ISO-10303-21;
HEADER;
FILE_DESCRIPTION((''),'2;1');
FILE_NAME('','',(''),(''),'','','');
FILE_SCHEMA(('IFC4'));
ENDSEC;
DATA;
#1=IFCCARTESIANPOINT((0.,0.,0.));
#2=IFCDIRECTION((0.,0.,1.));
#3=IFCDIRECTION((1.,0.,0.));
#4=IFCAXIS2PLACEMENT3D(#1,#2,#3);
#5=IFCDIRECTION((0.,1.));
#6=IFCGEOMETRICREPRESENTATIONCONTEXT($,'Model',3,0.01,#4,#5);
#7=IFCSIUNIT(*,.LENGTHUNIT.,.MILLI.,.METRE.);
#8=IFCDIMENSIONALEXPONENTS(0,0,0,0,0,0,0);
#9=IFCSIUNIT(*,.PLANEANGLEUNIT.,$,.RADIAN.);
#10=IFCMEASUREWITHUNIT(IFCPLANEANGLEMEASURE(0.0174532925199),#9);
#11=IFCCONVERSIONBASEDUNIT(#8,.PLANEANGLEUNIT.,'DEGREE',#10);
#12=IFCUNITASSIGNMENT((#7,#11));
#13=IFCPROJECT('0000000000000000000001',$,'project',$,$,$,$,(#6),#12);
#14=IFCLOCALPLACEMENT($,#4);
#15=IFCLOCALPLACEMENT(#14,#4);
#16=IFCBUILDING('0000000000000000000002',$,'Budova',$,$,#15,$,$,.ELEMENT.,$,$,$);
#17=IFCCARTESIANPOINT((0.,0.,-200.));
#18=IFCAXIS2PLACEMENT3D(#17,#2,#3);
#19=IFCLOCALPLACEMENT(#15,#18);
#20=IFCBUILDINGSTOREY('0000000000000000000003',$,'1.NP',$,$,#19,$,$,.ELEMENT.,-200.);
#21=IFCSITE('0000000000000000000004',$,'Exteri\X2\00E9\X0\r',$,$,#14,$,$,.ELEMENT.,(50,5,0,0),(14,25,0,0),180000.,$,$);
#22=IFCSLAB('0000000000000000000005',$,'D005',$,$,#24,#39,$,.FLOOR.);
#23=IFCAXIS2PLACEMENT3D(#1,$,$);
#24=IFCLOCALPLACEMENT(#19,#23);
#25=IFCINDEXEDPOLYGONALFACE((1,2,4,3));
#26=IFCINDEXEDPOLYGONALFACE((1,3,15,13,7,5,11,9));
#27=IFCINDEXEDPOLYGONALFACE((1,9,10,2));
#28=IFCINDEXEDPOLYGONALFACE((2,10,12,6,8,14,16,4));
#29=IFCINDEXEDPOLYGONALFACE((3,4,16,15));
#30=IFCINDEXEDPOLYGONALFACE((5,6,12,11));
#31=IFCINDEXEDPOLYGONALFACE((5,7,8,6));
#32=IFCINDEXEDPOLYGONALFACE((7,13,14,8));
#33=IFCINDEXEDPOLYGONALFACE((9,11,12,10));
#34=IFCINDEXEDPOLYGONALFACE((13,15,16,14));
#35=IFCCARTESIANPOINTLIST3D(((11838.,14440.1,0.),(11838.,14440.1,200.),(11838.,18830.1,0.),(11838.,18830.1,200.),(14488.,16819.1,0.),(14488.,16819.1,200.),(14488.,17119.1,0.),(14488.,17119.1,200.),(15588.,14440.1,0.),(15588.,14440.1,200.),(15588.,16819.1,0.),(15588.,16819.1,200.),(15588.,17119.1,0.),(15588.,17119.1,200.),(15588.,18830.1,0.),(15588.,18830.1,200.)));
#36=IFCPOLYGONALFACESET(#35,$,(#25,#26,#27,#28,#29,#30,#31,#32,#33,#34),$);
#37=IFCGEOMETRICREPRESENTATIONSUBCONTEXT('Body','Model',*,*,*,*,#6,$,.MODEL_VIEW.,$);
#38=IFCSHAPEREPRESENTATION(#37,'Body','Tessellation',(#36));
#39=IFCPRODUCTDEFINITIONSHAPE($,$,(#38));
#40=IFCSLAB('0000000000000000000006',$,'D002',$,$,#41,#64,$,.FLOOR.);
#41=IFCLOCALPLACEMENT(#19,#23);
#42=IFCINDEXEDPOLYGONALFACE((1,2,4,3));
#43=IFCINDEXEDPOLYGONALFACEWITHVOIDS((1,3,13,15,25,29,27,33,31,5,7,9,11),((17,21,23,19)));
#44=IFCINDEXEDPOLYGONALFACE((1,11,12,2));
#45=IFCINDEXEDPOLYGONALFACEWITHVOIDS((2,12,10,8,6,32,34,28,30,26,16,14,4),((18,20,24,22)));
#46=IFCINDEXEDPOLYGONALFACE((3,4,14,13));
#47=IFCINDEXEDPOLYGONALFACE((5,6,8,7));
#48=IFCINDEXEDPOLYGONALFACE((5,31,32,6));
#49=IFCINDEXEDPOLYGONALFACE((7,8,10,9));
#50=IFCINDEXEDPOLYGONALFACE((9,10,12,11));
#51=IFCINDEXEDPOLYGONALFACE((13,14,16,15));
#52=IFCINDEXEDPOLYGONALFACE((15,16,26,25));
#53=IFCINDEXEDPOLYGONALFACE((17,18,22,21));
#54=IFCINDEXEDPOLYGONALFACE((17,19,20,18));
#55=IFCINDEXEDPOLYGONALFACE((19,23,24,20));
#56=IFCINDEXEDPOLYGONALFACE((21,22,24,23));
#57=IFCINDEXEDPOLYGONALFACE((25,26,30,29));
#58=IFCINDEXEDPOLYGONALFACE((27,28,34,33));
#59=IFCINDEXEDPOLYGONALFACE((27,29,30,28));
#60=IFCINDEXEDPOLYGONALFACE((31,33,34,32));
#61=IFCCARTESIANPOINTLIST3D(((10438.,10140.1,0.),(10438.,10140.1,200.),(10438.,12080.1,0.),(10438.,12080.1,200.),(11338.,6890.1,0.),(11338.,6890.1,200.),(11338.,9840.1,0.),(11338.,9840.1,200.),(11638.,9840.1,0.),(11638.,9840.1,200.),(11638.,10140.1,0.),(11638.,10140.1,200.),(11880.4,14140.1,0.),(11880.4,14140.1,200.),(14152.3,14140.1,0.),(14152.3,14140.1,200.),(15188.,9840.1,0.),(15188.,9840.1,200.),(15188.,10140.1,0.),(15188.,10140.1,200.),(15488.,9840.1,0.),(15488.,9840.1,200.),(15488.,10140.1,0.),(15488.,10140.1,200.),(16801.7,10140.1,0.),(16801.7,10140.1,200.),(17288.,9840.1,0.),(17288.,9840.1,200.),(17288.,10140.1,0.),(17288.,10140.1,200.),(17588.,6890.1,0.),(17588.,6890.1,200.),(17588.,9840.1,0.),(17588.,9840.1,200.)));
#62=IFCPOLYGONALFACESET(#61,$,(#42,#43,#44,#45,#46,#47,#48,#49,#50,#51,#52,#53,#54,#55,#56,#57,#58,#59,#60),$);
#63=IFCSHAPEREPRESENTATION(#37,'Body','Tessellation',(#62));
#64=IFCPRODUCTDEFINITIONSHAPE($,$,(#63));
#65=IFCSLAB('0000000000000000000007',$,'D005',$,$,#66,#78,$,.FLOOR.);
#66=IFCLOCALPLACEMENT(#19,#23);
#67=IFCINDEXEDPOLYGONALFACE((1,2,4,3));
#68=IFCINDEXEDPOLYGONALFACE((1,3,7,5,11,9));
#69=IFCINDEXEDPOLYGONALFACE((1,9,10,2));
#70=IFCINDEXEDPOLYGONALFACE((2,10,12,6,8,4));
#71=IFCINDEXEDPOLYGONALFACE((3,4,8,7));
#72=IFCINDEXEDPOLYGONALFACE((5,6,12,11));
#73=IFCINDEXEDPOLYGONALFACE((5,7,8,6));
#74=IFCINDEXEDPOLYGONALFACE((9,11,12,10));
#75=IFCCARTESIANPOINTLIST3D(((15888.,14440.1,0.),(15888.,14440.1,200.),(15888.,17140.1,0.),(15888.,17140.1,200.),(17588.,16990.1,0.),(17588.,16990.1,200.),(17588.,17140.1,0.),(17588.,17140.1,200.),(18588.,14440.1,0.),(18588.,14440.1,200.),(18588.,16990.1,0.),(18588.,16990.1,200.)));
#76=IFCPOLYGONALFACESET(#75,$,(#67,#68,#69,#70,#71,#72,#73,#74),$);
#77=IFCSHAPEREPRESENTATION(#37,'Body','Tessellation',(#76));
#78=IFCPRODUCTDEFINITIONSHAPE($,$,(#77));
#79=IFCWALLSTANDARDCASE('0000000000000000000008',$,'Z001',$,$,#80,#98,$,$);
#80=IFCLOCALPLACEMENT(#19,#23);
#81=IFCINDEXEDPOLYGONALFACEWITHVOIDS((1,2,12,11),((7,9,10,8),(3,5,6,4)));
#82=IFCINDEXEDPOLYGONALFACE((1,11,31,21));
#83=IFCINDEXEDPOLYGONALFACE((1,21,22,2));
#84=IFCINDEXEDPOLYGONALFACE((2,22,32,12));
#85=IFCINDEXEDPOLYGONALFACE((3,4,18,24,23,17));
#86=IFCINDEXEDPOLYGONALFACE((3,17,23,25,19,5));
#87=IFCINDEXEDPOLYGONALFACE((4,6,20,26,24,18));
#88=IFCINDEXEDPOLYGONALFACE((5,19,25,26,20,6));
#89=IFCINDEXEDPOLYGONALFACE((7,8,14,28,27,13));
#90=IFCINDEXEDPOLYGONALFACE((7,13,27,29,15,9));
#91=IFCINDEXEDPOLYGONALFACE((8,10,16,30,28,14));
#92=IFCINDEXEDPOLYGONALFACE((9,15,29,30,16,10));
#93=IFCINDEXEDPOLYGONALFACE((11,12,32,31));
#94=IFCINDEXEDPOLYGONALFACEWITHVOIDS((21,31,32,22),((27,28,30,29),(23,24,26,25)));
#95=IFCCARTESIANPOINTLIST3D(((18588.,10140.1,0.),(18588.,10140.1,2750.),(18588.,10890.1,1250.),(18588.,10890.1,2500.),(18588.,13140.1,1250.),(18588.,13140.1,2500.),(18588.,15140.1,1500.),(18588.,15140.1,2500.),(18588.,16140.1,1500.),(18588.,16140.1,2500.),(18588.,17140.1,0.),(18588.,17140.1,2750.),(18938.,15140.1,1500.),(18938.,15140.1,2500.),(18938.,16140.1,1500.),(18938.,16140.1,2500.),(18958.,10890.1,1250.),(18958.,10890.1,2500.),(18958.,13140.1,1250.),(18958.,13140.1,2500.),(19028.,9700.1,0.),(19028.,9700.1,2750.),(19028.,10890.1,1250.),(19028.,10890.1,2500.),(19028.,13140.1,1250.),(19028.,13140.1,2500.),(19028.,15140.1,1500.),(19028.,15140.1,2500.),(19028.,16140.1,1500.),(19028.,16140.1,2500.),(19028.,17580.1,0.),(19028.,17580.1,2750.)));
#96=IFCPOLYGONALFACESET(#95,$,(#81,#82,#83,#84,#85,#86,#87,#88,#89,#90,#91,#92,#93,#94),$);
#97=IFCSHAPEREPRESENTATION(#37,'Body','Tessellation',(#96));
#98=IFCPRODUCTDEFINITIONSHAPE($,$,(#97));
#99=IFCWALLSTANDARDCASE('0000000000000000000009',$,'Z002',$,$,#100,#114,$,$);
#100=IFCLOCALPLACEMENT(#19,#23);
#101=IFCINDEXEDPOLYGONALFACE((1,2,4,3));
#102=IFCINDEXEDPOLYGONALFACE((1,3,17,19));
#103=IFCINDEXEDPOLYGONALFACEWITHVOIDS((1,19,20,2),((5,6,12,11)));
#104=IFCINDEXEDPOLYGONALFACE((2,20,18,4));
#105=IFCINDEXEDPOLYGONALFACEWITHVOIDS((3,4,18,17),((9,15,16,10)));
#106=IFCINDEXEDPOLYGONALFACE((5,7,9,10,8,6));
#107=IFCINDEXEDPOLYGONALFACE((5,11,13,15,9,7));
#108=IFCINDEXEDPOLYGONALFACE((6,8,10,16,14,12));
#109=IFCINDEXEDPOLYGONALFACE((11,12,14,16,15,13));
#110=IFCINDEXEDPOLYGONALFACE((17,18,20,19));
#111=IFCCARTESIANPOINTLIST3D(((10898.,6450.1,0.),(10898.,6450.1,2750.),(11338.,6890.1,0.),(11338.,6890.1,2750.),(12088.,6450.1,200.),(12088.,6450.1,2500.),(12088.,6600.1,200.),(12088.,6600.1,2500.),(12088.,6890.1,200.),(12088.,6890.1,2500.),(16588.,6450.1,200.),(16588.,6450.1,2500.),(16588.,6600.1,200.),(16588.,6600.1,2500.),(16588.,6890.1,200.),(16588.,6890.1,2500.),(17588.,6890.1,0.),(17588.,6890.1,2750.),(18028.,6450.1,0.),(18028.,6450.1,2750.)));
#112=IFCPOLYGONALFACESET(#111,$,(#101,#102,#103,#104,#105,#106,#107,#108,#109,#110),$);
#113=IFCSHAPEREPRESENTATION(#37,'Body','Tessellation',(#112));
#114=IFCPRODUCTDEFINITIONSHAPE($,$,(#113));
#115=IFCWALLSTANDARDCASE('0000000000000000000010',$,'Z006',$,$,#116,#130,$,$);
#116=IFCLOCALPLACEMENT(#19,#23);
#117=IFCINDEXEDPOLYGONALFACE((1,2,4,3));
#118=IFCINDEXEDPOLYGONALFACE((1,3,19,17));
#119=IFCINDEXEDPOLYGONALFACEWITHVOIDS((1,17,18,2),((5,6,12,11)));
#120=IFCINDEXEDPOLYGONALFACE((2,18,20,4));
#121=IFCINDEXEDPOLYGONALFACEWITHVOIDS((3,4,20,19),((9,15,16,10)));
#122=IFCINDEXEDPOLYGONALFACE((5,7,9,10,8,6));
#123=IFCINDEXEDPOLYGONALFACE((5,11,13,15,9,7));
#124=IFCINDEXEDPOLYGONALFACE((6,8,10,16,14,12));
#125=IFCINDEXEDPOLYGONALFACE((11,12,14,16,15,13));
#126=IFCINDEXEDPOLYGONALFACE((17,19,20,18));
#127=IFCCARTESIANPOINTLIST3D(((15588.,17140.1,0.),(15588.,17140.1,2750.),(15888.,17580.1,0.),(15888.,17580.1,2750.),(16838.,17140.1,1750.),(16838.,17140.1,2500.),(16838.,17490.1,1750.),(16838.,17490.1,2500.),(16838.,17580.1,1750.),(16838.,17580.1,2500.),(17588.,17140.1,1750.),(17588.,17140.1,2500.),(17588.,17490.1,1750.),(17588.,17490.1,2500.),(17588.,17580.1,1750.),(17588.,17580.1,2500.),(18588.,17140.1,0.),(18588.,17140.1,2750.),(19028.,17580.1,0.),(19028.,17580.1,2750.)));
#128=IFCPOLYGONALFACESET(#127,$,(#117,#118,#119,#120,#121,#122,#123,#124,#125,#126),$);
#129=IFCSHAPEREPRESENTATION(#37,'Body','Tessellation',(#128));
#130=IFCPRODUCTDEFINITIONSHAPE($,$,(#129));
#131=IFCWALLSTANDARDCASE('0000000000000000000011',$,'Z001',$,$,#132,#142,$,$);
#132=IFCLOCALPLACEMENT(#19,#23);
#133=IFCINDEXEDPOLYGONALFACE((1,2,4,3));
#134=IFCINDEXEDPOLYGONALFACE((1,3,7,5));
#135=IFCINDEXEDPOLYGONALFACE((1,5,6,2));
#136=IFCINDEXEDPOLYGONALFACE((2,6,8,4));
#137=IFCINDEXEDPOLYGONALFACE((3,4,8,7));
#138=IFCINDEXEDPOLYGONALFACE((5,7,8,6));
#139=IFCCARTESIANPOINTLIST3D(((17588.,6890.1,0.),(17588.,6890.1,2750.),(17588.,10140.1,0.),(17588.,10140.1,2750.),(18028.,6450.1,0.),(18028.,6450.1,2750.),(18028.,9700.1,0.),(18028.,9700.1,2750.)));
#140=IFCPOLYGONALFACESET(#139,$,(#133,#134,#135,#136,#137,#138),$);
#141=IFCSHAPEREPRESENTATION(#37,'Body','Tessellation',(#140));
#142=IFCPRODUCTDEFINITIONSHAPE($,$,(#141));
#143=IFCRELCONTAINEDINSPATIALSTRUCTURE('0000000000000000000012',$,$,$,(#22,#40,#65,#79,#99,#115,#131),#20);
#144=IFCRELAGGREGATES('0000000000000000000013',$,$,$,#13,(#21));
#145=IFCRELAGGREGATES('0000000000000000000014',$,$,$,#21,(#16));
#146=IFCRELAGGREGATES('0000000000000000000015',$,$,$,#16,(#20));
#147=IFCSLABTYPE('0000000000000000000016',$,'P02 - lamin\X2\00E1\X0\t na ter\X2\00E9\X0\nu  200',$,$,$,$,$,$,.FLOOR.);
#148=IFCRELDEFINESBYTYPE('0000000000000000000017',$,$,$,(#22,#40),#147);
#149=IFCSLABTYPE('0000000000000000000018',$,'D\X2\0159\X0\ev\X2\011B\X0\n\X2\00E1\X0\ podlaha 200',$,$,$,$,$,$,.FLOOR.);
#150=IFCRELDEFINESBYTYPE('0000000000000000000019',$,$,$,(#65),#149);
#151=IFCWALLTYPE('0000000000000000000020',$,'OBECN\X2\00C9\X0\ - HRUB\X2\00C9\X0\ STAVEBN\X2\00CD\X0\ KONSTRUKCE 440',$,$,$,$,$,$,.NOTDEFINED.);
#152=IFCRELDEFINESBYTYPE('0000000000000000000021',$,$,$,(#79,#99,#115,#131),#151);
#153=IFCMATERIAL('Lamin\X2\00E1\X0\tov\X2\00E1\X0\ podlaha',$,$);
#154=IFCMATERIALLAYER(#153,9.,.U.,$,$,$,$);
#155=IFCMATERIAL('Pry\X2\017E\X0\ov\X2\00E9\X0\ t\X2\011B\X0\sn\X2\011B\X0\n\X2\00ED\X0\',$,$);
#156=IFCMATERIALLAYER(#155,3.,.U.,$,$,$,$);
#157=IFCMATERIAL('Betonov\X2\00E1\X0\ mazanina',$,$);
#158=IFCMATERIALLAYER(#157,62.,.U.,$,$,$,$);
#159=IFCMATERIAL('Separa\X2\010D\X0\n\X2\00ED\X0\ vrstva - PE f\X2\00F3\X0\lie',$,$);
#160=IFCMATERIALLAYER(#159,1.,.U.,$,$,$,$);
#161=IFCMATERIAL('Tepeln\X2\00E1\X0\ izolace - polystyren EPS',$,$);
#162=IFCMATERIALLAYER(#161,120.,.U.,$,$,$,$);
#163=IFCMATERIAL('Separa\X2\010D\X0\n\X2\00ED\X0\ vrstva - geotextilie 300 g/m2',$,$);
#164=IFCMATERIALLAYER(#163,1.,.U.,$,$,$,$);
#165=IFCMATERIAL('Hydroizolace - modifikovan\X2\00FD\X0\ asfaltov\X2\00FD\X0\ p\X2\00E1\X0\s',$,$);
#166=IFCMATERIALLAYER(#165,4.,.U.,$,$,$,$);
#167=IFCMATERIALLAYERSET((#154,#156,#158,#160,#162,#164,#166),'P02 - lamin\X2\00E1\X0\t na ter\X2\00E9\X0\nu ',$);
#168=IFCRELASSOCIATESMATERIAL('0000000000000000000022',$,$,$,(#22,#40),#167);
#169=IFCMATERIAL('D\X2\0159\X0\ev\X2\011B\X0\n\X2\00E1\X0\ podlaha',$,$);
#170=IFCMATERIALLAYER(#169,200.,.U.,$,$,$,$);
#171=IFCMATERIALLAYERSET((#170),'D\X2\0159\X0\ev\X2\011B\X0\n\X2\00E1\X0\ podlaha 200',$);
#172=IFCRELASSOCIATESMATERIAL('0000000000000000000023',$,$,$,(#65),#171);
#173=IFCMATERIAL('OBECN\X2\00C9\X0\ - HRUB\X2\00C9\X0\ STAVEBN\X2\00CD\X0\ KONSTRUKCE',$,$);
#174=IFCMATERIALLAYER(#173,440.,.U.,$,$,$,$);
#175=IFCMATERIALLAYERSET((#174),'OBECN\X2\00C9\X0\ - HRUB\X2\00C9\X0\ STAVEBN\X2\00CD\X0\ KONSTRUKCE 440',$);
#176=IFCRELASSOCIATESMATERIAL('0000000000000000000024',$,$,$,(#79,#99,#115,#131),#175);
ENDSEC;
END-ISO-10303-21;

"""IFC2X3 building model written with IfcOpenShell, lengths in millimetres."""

from ifc_helpers import new_model, entity, si_unit, converted_unit, direction, frame, origin_with_axes, origin_2d_with_axis, place, context, subcontext, project, spatial, polyline, rectangle, outline, extrude, material, layer, layer_set, layer_usage, type_object, element, save


model = new_model("IFC2X3")

# Units and contexts
model_context = context("Model", 3, precision=0.01, world=origin_with_axes(), true_north=direction((0.0, 1.0)))
body_context = subcontext(model_context, "Body", "Model", "MODEL_VIEW")
ifc_project = project(units=[si_unit("LENGTHUNIT", "METRE", prefix="MILLI"), converted_unit("PLANEANGLEUNIT", "DEGREE", entity("IfcPlaneAngleMeasure", 0.0174532925199), si_unit("PLANEANGLEUNIT", "RADIAN"), dimensions=[0, 0, 0, 0, 0, 0, 0])], contexts=[model_context])

# Site, building, storey
site_placement = place(None, origin_with_axes())
site = spatial("IfcSite", under=ifc_project, at=site_placement, Name="Exteriér", CompositionType="ELEMENT", RefLatitude=(50, 5, 0, 0), RefLongitude=(14, 25, 0, 0), RefElevation=180000.0)
building_placement = place(site_placement, origin_with_axes())
building = spatial("IfcBuilding", under=site, at=building_placement, Name="Budova", CompositionType="ELEMENT")
storey_placement = place(building_placement, frame((0.0, 0.0, -200.0), z_axis=(0.0, 0.0, 1.0), x_axis=(1.0, 0.0, 0.0)))
storey = spatial("IfcBuildingStorey", under=building, at=storey_placement, Name="1.NP", CompositionType="ELEMENT", Elevation=-200.0)

# Slabs
ifc_material_1 = material(Name="Laminátová podlaha")
ifc_layer_1 = layer(ifc_material_1, 9.0, ventilated="UNKNOWN")
ifc_material_2 = material(Name="Pryžové těsnění")
ifc_layer_2 = layer(ifc_material_2, 3.0, ventilated="UNKNOWN")
ifc_material_3 = material(Name="Betonová mazanina")
ifc_layer_3 = layer(ifc_material_3, 62.0, ventilated="UNKNOWN")
ifc_material_4 = material(Name="Separační vrstva - PE fólie")
ifc_layer_4 = layer(ifc_material_4, 1.0, ventilated="UNKNOWN")
ifc_material_5 = material(Name="Tepelná izolace - polystyren EPS")
ifc_layer_5 = layer(ifc_material_5, 120.0, ventilated="UNKNOWN")
ifc_material_6 = material(Name="Separační vrstva - geotextilie 300 g/m2")
ifc_layer_6 = layer(ifc_material_6, 1.0, ventilated="UNKNOWN")
ifc_material_7 = material(Name="Hydroizolace - modifikovaný asfaltový pás")
ifc_layer_7 = layer(ifc_material_7, 4.0, ventilated="UNKNOWN")
ifc_layer_set_1 = layer_set([ifc_layer_1, ifc_layer_2, ifc_layer_3, ifc_layer_4, ifc_layer_5, ifc_layer_6, ifc_layer_7], Name="P02 - laminát na terénu ")
ifc_layer_usage_1 = layer_usage(ifc_layer_set_1, "AXIS3", "NEGATIVE", 200.0)
slab_type_1 = type_object("IfcSlabType", Name="P02 - laminát na terénu  200", PredefinedType="FLOOR")
slab_1_placement = place(storey_placement, frame((11838.0, 18830.1, 0.0), z_axis=(0.0, 0.0, 1.0), x_axis=(1.0, 0.0, 0.0)))
element("IfcSlab", 1, at=slab_1_placement, inside=storey, type_object=slab_type_1, material=ifc_layer_usage_1, Name="D005", PredefinedType="FLOOR", context=body_context, shape_type="SweptSolid", body=[
    extrude(outline(polyline([(0.0, 0.0), (0.0, -4390.0), (3750.0, -4390.0), (3750.0, -2011.0), (2650.0, -2011.0), (2650.0, -1711.0), (3750.0, -1711.0), (3750.0, 0.0), (0.0, 0.0)])), origin_with_axes(), (0.0, 0.0, 1.0), 200.0),
])
ifc_layer_usage_2 = layer_usage(ifc_layer_set_1, "AXIS3", "NEGATIVE", 200.0)
slab_2_placement = place(storey_placement, frame((11880.4, 14140.1, 0.0), z_axis=(0.0, 0.0, 1.0), x_axis=(1.0, 0.0, 0.0)))
element("IfcSlab", 2, at=slab_2_placement, inside=storey, type_object=slab_type_1, material=ifc_layer_usage_2, Name="D002", PredefinedType="FLOOR", context=body_context, shape_type="SweptSolid", body=[
    extrude(outline(polyline([(0.0, 0.0), (-1442.4, -2060.0), (-1442.4, -4000.0), (-242.4, -4000.0), (-242.4, -4300.0), (-542.4, -4300.0), (-542.4, -7250.0), (5707.6, -7250.0), (5707.6, -4300.0), (5407.6, -4300.0), (5407.6, -4000.0), (4921.3, -4000.0), (2271.9, 0.0), (0.0, 0.0)]), holes=[polyline([(3607.6, -4300.0), (3307.6, -4300.0), (3307.6, -4000.0), (3607.6, -4000.0), (3607.6, -4300.0)])]), origin_with_axes(), (0.0, 0.0, 1.0), 200.0),
])
ifc_material_8 = material(Name="Dřevěná podlaha")
ifc_layer_8 = layer(ifc_material_8, 200.0, ventilated="UNKNOWN")
ifc_layer_set_2 = layer_set([ifc_layer_8], Name="Dřevěná podlaha 200")
ifc_layer_usage_3 = layer_usage(ifc_layer_set_2, "AXIS3", "NEGATIVE", 200.0)
slab_type_2 = type_object("IfcSlabType", Name="Dřevěná podlaha 200", PredefinedType="FLOOR")
slab_3_placement = place(storey_placement, frame((15888.0, 14440.1, 0.0), z_axis=(0.0, 0.0, 1.0), x_axis=(1.0, 0.0, 0.0)))
element("IfcSlab", 3, at=slab_3_placement, inside=storey, type_object=slab_type_2, material=ifc_layer_usage_3, Name="D005", PredefinedType="FLOOR", context=body_context, shape_type="SweptSolid", body=[
    extrude(outline(polyline([(0.0, 0.0), (2700.0, 0.0), (2700.0, 2550.0), (1700.0, 2550.0), (1700.0, 2700.0), (0.0, 2700.0), (0.0, 0.0)])), origin_with_axes(), (0.0, 0.0, 1.0), 200.0),
])

# Wall, openings
ifc_material_9 = material(Name="OBECNÉ - HRUBÉ STAVEBNÍ KONSTRUKCE")
ifc_layer_9 = layer(ifc_material_9, 440.0, ventilated="UNKNOWN")
ifc_layer_set_3 = layer_set([ifc_layer_9], Name="OBECNÉ - HRUBÉ STAVEBNÍ KONSTRUKCE 440")
ifc_layer_usage_4 = layer_usage(ifc_layer_set_3, "AXIS2", "NEGATIVE", 0.0)
wall_type_1 = type_object("IfcWallType", Name="OBECNÉ - HRUBÉ STAVEBNÍ KONSTRUKCE 440", PredefinedType="NOTDEFINED")
wall_1_placement = place(storey_placement, frame((19028.0, 17580.1, 0.0), z_axis=(0.0, 0.0, 1.0), x_axis=(0.0, -1.0, 0.0)))
wall_1 = element("IfcWallStandardCase", 4, at=wall_1_placement, inside=storey, type_object=wall_type_1, material=ifc_layer_usage_4, Name="Z001", context=body_context, shape_type="SweptSolid", body=[
    extrude(outline(polyline([(440.0, -440.0), (7440.0, -440.0), (7880.0, 0.0), (0.0, 0.0), (440.0, -440.0)])), origin_with_axes(), (0.0, 0.0, 1.0), 2750.0),
])
opening_1_placement = place(wall_1_placement, frame((1940.0, 0.0, 1500.0), z_axis=(0.0, 0.0, 1.0), x_axis=(1.0, 0.0, 0.0)))
element("IfcOpeningElement", 5, at=opening_1_placement, cuts=wall_1, context=body_context, shape_type="SweptSolid", body=[
    extrude(rectangle(XDim=1000.0, YDim=1000.0, at=origin_2d_with_axis()), frame((0.0, -90.0, 500.0), z_axis=(0.0, 1.0, 0.0), x_axis=(-1.0, 0.0, 0.0)), (0.0, 0.0, -1.0), 790.0),
    extrude(rectangle(XDim=1000.0, YDim=1000.0, at=origin_2d_with_axis()), frame((0.0, -90.0, 500.0), z_axis=(0.0, -1.0, 0.0), x_axis=(-1.0, 0.0, 0.0)), (0.0, 0.0, -1.0), 530.0),
])
opening_2_placement = place(wall_1_placement, frame((5565.0, 0.0, 1250.0), z_axis=(0.0, 0.0, 1.0), x_axis=(1.0, 0.0, 0.0)))
element("IfcOpeningElement", 6, at=opening_2_placement, cuts=wall_1, context=body_context, shape_type="SweptSolid", body=[
    extrude(rectangle(XDim=2250.0, YDim=1250.0, at=origin_2d_with_axis()), frame((0.0, -70.0, 625.0), z_axis=(0.0, 1.0, 0.0), x_axis=(-1.0, 0.0, 0.0)), (0.0, 0.0, -1.0), 810.0),
    extrude(rectangle(XDim=2250.0, YDim=1250.0, at=origin_2d_with_axis()), frame((0.0, -70.0, 625.0), z_axis=(0.0, -1.0, 0.0), x_axis=(-1.0, 0.0, 0.0)), (0.0, 0.0, -1.0), 510.0),
])

# Walls, openings
ifc_layer_usage_5 = layer_usage(ifc_layer_set_3, "AXIS2", "NEGATIVE", 0.0)
wall_2_placement = place(storey_placement, frame((18028.0, 6450.1, 0.0), z_axis=(0.0, 0.0, 1.0), x_axis=(-1.0, 0.0, 0.0)))
wall_2 = element("IfcWallStandardCase", 7, at=wall_2_placement, inside=storey, type_object=wall_type_1, material=ifc_layer_usage_5, Name="Z002", context=body_context, shape_type="SweptSolid", body=[
    extrude(outline(polyline([(440.0, -440.0), (6690.0, -440.0), (7130.0, 0.0), (0.0, 0.0), (440.0, -440.0)])), origin_with_axes(), (0.0, 0.0, 1.0), 2750.0),
])
opening_3_placement = place(wall_2_placement, frame((3690.0, 0.0, 200.0), z_axis=(0.0, 0.0, 1.0), x_axis=(1.0, 0.0, 0.0)))
element("IfcOpeningElement", 8, at=opening_3_placement, cuts=wall_2, context=body_context, shape_type="SweptSolid", body=[
    extrude(rectangle(XDim=4500.0, YDim=2300.0, at=origin_2d_with_axis()), frame((0.0, -150.0, 1150.0), z_axis=(0.0, -1.0, 0.0), x_axis=(1.0, 0.0, 0.0)), (0.0, 0.0, 1.0), 730.0),
    extrude(rectangle(XDim=4500.0, YDim=2300.0, at=origin_2d_with_axis()), frame((0.0, -150.0, 1150.0), z_axis=(0.0, 1.0, 0.0), x_axis=(1.0, 0.0, 0.0)), (0.0, 0.0, 1.0), 590.0),
])
ifc_layer_usage_6 = layer_usage(ifc_layer_set_3, "AXIS2", "NEGATIVE", 0.0)
wall_3_placement = place(storey_placement, frame((15888.0, 17580.1, 0.0), z_axis=(0.0, 0.0, 1.0), x_axis=(1.0, 0.0, 0.0)))
wall_3 = element("IfcWallStandardCase", 9, at=wall_3_placement, inside=storey, type_object=wall_type_1, material=ifc_layer_usage_6, Name="Z006", context=body_context, shape_type="SweptSolid", body=[
    extrude(outline(polyline([(-300.0, -440.0), (2700.0, -440.0), (3140.0, 0.0), (0.0, 0.0), (-300.0, -440.0)])), origin_with_axes(), (0.0, 0.0, 1.0), 2750.0),
])
opening_4_placement = place(wall_3_placement, frame((1325.0, 0.0, 1750.0), z_axis=(0.0, 0.0, 1.0), x_axis=(1.0, 0.0, 0.0)))
element("IfcOpeningElement", 10, at=opening_4_placement, cuts=wall_3, context=body_context, shape_type="SweptSolid", body=[
    extrude(rectangle(XDim=750.0, YDim=750.0, at=origin_2d_with_axis()), frame((0.0, -90.0, 375.0), z_axis=(0.0, 1.0, 0.0), x_axis=(-1.0, 0.0, 0.0)), (0.0, 0.0, -1.0), 790.0),
    extrude(rectangle(XDim=750.0, YDim=750.0, at=origin_2d_with_axis()), frame((0.0, -90.0, 375.0), z_axis=(0.0, -1.0, 0.0), x_axis=(-1.0, 0.0, 0.0)), (0.0, 0.0, -1.0), 530.0),
])

# Wall
ifc_layer_usage_7 = layer_usage(ifc_layer_set_3, "AXIS2", "NEGATIVE", 0.0)
wall_4_placement = place(storey_placement, frame((18028.0, 9700.1, 0.0), z_axis=(0.0, 0.0, 1.0), x_axis=(0.0, -1.0, 0.0)))
element("IfcWallStandardCase", 11, at=wall_4_placement, inside=storey, type_object=wall_type_1, material=ifc_layer_usage_7, Name="Z001", context=body_context, shape_type="SweptSolid", body=[
    extrude(outline(polyline([(-440.0, -440.0), (2810.0, -440.0), (3250.0, 0.0), (0.0, 0.0), (-440.0, -440.0)])), origin_with_axes(), (0.0, 0.0, 1.0), 2750.0),
])

save(model, "model.ifc")
